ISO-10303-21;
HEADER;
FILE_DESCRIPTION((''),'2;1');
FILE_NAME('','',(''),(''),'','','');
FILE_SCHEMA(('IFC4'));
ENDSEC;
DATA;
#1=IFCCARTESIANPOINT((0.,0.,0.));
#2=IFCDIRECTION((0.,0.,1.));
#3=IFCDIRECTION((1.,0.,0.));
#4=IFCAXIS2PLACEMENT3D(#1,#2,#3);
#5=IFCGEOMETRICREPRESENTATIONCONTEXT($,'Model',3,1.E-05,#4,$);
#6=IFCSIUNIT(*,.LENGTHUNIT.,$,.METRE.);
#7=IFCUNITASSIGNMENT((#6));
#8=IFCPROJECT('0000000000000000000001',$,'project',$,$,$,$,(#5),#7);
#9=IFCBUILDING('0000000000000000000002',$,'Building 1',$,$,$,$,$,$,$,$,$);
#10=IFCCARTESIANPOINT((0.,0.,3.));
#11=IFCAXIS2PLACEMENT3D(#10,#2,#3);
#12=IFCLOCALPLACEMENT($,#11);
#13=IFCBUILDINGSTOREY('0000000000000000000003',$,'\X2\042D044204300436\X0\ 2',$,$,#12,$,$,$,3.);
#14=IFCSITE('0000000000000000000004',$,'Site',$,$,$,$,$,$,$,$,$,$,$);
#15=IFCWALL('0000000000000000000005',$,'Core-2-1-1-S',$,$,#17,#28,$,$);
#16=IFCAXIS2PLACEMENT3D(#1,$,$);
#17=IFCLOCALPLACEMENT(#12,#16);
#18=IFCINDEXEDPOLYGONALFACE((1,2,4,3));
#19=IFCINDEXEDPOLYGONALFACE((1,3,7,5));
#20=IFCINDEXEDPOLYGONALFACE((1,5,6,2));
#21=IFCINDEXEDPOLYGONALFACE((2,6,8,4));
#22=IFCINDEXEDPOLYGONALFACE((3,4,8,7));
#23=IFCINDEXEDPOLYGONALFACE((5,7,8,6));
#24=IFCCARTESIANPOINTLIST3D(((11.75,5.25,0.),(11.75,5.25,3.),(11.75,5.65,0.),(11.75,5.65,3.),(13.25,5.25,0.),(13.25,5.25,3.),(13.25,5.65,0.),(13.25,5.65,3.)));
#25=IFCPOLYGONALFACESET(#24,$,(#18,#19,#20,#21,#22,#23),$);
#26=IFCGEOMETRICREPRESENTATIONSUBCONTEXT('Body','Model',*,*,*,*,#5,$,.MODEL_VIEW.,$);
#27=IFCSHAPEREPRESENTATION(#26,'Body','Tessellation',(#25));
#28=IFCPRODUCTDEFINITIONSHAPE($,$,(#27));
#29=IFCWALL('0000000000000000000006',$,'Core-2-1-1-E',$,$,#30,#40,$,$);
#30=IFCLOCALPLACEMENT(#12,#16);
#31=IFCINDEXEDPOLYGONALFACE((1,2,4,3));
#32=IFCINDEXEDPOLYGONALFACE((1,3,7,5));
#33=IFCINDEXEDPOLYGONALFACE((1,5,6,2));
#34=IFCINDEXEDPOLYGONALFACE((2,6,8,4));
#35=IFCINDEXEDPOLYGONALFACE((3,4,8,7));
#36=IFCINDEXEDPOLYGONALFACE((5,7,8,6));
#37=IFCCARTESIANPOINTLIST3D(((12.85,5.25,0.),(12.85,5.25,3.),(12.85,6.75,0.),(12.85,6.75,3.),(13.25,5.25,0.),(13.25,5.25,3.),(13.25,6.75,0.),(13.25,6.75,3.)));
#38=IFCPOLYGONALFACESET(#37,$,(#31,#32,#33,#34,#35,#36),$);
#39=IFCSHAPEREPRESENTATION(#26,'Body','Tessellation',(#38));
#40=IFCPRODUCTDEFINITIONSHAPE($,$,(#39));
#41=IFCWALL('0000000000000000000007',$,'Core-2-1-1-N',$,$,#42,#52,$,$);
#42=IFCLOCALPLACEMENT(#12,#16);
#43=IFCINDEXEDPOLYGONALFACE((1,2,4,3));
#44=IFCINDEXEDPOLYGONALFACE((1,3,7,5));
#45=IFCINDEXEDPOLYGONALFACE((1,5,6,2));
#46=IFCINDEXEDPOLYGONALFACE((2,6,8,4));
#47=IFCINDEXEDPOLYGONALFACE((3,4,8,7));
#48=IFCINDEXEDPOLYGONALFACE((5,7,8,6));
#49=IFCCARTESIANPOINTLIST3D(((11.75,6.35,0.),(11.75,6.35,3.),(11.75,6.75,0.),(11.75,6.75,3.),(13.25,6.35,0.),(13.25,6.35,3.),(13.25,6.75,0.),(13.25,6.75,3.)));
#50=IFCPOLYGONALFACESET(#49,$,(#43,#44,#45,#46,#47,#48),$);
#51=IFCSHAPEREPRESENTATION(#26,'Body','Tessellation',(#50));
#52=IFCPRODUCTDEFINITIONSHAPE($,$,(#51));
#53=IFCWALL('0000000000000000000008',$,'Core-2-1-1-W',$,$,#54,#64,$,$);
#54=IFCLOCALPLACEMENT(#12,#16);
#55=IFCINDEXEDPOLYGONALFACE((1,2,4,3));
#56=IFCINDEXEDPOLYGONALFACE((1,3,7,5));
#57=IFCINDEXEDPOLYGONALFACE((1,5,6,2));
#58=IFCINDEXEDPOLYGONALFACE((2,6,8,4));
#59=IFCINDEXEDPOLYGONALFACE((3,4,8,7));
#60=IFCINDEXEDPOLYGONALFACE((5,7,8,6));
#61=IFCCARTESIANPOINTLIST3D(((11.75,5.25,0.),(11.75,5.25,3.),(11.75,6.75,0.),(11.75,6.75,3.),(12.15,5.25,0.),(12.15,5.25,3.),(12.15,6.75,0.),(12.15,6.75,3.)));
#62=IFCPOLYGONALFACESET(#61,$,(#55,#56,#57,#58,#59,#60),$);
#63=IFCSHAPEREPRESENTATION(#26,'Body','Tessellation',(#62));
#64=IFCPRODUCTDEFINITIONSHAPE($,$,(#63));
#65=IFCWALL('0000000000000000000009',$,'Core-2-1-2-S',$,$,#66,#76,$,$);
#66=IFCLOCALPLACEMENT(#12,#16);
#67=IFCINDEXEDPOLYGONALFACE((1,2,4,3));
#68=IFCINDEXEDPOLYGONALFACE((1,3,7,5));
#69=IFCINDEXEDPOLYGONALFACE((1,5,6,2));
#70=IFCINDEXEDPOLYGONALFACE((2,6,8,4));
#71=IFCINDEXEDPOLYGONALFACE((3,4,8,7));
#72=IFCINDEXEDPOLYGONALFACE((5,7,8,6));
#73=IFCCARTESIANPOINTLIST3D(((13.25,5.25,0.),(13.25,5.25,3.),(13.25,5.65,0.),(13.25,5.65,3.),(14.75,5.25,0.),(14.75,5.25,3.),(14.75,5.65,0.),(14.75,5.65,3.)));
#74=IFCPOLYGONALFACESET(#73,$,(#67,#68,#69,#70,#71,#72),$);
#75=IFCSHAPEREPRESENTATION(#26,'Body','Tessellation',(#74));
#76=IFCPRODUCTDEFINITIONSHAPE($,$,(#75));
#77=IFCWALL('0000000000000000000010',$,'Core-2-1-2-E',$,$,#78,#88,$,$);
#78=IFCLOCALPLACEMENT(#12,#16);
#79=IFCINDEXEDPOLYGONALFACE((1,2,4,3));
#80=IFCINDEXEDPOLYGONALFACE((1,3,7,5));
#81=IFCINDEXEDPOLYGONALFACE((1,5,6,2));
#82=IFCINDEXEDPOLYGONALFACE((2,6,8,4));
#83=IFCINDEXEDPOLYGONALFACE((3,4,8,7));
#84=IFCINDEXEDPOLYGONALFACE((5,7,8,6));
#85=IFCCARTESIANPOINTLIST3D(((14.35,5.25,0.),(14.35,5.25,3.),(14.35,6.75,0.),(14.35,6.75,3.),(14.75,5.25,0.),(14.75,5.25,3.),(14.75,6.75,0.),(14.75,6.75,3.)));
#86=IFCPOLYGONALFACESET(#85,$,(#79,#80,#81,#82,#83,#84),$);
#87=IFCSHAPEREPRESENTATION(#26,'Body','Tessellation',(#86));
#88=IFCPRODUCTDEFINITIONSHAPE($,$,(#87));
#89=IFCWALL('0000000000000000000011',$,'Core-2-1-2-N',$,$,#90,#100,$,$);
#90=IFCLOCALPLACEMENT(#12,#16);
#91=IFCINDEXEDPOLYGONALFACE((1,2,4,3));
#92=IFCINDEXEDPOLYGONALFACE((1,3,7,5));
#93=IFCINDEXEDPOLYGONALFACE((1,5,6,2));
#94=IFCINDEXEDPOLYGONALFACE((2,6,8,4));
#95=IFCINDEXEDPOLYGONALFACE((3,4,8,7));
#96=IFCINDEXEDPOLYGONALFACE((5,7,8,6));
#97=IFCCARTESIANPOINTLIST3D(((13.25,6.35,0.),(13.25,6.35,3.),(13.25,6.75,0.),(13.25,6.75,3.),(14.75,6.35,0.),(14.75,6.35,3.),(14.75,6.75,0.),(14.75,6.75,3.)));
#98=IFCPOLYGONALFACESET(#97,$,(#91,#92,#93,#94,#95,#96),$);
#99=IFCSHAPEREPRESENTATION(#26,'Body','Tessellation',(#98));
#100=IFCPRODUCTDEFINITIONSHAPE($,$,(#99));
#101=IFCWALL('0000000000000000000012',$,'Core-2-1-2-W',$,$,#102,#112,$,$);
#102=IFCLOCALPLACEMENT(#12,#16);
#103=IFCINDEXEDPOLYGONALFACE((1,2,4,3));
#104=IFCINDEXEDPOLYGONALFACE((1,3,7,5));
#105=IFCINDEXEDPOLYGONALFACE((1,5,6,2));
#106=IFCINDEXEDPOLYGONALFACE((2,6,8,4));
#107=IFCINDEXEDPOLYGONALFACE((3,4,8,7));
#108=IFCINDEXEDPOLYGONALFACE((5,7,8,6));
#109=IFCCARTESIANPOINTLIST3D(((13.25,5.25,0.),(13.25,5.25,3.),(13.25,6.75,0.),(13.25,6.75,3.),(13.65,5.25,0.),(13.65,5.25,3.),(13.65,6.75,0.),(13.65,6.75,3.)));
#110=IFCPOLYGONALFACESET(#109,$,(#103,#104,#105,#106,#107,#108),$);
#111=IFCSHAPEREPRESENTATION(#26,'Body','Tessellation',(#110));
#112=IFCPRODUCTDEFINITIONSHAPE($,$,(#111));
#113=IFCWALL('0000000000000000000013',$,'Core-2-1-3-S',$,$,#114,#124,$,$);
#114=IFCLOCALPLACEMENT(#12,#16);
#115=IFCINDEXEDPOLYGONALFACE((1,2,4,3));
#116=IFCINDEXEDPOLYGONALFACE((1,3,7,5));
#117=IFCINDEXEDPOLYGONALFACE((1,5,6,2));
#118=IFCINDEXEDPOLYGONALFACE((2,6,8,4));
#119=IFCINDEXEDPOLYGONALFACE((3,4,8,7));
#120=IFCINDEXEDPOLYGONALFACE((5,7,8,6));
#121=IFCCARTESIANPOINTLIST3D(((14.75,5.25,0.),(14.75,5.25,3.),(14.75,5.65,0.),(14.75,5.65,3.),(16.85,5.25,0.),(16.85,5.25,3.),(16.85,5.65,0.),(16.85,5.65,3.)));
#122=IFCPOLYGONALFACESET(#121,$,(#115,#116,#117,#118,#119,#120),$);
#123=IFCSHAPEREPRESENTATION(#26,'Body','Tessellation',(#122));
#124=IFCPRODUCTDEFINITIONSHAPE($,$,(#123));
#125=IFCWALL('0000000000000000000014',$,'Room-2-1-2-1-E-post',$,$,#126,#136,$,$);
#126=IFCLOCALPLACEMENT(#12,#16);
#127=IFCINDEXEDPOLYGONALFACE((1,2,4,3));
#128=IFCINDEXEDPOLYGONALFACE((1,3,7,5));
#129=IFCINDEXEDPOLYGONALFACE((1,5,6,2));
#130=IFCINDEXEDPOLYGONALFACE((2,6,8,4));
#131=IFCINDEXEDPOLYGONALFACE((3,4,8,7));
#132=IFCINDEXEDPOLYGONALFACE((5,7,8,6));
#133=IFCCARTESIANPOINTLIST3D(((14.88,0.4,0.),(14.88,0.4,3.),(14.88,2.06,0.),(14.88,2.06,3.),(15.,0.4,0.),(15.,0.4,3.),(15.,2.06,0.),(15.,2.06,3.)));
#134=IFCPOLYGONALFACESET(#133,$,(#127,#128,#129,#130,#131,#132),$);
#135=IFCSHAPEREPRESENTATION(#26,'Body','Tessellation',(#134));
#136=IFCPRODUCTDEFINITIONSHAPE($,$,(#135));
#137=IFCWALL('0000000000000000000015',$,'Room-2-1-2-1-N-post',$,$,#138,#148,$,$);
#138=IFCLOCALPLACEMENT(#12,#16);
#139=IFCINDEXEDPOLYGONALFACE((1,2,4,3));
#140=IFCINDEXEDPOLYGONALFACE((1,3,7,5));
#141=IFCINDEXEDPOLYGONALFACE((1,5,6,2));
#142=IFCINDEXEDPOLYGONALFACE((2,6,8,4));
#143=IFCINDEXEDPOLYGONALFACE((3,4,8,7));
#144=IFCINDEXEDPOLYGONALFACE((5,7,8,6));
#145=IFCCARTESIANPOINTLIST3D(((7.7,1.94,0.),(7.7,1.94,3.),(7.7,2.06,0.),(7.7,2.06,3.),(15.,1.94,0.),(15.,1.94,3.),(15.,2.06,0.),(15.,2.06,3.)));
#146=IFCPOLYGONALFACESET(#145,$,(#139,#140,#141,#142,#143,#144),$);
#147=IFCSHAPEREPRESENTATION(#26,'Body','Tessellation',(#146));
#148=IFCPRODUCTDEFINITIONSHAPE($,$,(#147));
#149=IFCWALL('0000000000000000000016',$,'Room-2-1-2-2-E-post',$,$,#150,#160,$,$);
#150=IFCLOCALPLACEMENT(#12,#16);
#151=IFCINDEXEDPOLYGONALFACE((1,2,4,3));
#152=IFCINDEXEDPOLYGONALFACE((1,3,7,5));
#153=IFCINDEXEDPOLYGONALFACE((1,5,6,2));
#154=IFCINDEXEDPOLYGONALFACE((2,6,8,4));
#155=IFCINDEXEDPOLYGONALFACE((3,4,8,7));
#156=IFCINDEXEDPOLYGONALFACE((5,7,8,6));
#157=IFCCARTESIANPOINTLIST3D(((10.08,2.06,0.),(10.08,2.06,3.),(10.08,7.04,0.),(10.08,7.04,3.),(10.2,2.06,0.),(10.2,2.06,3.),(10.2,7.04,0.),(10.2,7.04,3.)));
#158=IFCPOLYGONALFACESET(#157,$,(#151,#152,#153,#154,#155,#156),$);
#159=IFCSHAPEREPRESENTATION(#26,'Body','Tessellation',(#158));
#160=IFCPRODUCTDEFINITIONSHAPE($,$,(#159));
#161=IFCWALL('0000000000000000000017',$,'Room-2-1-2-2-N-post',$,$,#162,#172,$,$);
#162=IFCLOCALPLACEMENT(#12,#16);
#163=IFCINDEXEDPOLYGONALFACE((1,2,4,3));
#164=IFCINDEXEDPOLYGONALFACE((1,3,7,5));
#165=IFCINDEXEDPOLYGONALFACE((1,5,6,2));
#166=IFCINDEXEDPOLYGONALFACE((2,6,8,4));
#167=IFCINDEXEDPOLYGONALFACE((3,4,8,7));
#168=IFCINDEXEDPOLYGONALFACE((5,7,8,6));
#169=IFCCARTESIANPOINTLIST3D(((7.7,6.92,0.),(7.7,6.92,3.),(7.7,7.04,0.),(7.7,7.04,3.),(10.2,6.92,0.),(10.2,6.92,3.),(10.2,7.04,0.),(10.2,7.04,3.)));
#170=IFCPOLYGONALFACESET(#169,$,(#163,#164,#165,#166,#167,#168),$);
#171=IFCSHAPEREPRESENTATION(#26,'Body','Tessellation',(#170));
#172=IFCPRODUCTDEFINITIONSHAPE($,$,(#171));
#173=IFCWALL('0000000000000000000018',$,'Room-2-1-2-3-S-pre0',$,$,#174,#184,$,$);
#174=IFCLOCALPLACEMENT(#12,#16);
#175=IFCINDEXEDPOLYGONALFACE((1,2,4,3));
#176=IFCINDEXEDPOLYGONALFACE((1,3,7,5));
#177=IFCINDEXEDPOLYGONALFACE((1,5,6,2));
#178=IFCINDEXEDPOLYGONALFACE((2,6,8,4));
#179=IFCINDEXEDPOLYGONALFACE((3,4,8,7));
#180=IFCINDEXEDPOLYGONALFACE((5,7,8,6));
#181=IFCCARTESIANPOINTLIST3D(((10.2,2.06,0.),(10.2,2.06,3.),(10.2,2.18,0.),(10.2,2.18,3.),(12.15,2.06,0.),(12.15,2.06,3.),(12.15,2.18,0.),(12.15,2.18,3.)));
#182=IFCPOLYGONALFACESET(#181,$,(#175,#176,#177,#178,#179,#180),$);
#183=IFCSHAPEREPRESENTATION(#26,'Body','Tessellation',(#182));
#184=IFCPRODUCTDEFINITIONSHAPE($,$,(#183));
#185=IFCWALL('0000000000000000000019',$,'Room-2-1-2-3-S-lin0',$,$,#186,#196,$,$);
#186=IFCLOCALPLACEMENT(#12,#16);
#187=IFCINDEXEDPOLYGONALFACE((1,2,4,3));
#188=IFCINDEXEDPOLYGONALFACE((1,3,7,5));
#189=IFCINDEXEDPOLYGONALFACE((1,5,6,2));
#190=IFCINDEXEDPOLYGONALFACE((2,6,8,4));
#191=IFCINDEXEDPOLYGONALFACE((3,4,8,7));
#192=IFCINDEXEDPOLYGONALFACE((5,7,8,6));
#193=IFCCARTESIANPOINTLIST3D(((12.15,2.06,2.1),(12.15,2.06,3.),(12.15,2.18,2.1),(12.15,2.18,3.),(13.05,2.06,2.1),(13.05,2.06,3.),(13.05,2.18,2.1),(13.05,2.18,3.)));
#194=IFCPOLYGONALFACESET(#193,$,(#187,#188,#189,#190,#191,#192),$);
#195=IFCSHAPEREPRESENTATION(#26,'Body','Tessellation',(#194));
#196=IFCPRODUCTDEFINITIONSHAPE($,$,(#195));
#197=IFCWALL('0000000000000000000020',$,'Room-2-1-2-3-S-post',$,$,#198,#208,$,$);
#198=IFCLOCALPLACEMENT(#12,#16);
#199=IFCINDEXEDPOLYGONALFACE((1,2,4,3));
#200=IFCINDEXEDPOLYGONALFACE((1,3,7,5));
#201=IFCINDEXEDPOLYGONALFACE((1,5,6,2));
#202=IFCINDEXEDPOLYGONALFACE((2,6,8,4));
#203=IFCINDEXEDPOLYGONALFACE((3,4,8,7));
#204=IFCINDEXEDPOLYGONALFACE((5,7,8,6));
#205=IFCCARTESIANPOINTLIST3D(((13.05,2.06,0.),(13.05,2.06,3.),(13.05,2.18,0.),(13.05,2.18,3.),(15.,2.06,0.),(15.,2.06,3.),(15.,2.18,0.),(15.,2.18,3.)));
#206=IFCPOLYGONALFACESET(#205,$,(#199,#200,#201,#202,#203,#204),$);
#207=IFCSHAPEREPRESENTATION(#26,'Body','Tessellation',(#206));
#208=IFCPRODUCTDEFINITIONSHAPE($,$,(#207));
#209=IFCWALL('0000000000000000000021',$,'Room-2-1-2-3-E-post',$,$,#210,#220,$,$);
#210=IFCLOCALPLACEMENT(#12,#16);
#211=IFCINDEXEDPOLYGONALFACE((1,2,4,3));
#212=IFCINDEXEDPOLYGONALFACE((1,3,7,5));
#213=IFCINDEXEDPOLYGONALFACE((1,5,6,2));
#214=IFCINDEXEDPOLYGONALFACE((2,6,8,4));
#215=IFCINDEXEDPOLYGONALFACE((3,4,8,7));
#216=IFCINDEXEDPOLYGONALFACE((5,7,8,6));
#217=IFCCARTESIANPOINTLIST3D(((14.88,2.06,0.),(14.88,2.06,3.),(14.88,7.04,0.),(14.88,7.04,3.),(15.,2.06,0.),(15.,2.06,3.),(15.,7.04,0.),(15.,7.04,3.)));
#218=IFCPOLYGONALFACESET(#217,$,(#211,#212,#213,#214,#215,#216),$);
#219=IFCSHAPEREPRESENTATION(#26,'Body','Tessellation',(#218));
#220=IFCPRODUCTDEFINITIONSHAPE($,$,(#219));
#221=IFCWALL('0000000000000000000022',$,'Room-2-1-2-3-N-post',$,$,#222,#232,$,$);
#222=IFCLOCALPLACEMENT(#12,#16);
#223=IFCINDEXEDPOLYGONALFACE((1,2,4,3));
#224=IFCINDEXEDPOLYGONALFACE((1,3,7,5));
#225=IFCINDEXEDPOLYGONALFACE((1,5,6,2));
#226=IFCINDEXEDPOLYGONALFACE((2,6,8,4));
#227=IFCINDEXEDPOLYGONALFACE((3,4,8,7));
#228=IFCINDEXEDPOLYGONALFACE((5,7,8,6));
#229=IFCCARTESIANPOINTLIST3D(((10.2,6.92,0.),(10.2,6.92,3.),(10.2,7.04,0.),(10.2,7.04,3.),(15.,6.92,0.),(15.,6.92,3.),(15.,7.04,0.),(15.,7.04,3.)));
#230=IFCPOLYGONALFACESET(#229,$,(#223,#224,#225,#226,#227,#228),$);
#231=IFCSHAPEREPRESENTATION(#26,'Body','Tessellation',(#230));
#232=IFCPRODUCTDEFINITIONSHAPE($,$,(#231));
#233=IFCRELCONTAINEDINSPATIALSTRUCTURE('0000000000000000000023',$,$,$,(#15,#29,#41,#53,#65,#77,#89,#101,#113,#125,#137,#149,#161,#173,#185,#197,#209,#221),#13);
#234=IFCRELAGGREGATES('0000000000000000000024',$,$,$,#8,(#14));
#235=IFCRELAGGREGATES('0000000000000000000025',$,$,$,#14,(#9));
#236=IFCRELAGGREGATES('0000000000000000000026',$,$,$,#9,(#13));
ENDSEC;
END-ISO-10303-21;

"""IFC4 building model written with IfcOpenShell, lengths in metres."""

from ifc_helpers import new_model, si_unit, frame, origin_with_axes, place, context, subcontext, project, spatial, indexed_curve, outline, extrude, element, save


model = new_model("IFC4")

# Units and contexts
model_context = context("Model", 3, precision=1e-05, world=origin_with_axes())
body_context = subcontext(model_context, "Body", "Model", "MODEL_VIEW")
ifc_project = project(units=[si_unit("LENGTHUNIT", "METRE")], contexts=[model_context])

# Site, building, storey
site = spatial("IfcSite", under=ifc_project, Name="Site")
building = spatial("IfcBuilding", under=site, Name="Building 1")
storey_placement = place(None, frame((0.0, 0.0, 3.0), z_axis=(0.0, 0.0, 1.0), x_axis=(1.0, 0.0, 0.0)))
storey = spatial("IfcBuildingStorey", under=building, at=storey_placement, Name="Этаж 2", Elevation=3.0)

# Walls
for number, where, z_axis, x_axis, name in (
    (1, (11.75, 5.25, 0.0), (0.0, 0.0, 1.0), (1.0, 0.0, 0.0), "Core-2-1-1-S"),
    (2, (13.25, 5.25, 0.0), (0.0, 0.0, 1.0), (0.0, 1.0, 0.0), "Core-2-1-1-E"),
    (3, (13.25, 6.75, 0.0), (0.0, 0.0, 1.0), (-1.0, 0.0, 0.0), "Core-2-1-1-N"),
    (4, (11.75, 6.75, 0.0), (0.0, 0.0, 1.0), (0.0, -1.0, 0.0), "Core-2-1-1-W"),
    (5, (13.25, 5.25, 0.0), (0.0, 0.0, 1.0), (1.0, 0.0, 0.0), "Core-2-1-2-S"),
    (6, (14.75, 5.25, 0.0), (0.0, 0.0, 1.0), (0.0, 1.0, 0.0), "Core-2-1-2-E"),
    (7, (14.75, 6.75, 0.0), (0.0, 0.0, 1.0), (-1.0, 0.0, 0.0), "Core-2-1-2-N"),
    (8, (13.25, 6.75, 0.0), (0.0, 0.0, 1.0), (0.0, -1.0, 0.0), "Core-2-1-2-W"),
):
    element("IfcWall", number, at=place(storey_placement, frame(where, z_axis=z_axis, x_axis=x_axis)), inside=storey, Name=name, context=body_context, shape_type="SweptSolid", body=[
        extrude(outline(indexed_curve([(0.0, 0.0), (0.0, 0.4), (1.5, 0.4), (1.5, 0.0), (0.0, 0.0)], self_intersect=False)), origin_with_axes(), (0.0, 0.0, 1.0), 3.0),
    ])
wall_1_placement = place(storey_placement, frame((14.75, 5.25, 0.0), z_axis=(0.0, 0.0, 1.0), x_axis=(1.0, 0.0, 0.0)))
element("IfcWall", 9, at=wall_1_placement, inside=storey, Name="Core-2-1-3-S", context=body_context, shape_type="SweptSolid", body=[
    extrude(outline(indexed_curve([(0.0, 0.0), (0.0, 0.4), (2.1, 0.4), (2.1, 0.0), (0.0, 0.0)], self_intersect=False)), origin_with_axes(), (0.0, 0.0, 1.0), 3.0),
])
wall_2_placement = place(storey_placement, frame((15.0, 0.4, 0.0), z_axis=(0.0, 0.0, 1.0), x_axis=(0.0, 1.0, 0.0)))
element("IfcWall", 10, at=wall_2_placement, inside=storey, Name="Room-2-1-2-1-E-post", context=body_context, shape_type="SweptSolid", body=[
    extrude(outline(indexed_curve([(0.0, 0.0), (0.0, 0.12), (1.66, 0.12), (1.66, 0.0), (0.0, 0.0)], self_intersect=False)), origin_with_axes(), (0.0, 0.0, 1.0), 3.0),
])
wall_3_placement = place(storey_placement, frame((15.0, 2.06, 0.0), z_axis=(0.0, 0.0, 1.0), x_axis=(-1.0, 0.0, 0.0)))
element("IfcWall", 11, at=wall_3_placement, inside=storey, Name="Room-2-1-2-1-N-post", context=body_context, shape_type="SweptSolid", body=[
    extrude(outline(indexed_curve([(0.0, 0.0), (0.0, 0.12), (7.3, 0.12), (7.3, 0.0), (0.0, 0.0)], self_intersect=False)), origin_with_axes(), (0.0, 0.0, 1.0), 3.0),
])
wall_4_placement = place(storey_placement, frame((10.2, 2.06, 0.0), z_axis=(0.0, 0.0, 1.0), x_axis=(0.0, 1.0, 0.0)))
element("IfcWall", 12, at=wall_4_placement, inside=storey, Name="Room-2-1-2-2-E-post", context=body_context, shape_type="SweptSolid", body=[
    extrude(outline(indexed_curve([(0.0, 0.0), (0.0, 0.12), (4.98, 0.12), (4.98, 0.0), (0.0, 0.0)], self_intersect=False)), origin_with_axes(), (0.0, 0.0, 1.0), 3.0),
])
wall_5_placement = place(storey_placement, frame((10.2, 7.04, 0.0), z_axis=(0.0, 0.0, 1.0), x_axis=(-1.0, 0.0, 0.0)))
element("IfcWall", 13, at=wall_5_placement, inside=storey, Name="Room-2-1-2-2-N-post", context=body_context, shape_type="SweptSolid", body=[
    extrude(outline(indexed_curve([(0.0, 0.0), (0.0, 0.12), (2.5, 0.12), (2.5, 0.0), (0.0, 0.0)], self_intersect=False)), origin_with_axes(), (0.0, 0.0, 1.0), 3.0),
])
wall_6_placement = place(storey_placement, frame((10.2, 2.06, 0.0), z_axis=(0.0, 0.0, 1.0), x_axis=(1.0, 0.0, 0.0)))
element("IfcWall", 14, at=wall_6_placement, inside=storey, Name="Room-2-1-2-3-S-pre0", context=body_context, shape_type="SweptSolid", body=[
    extrude(outline(indexed_curve([(0.0, 0.0), (0.0, 0.12), (1.95, 0.12), (1.95, 0.0), (0.0, 0.0)], self_intersect=False)), origin_with_axes(), (0.0, 0.0, 1.0), 3.0),
])
wall_7_placement = place(storey_placement, frame((12.15, 2.06, 2.1), z_axis=(0.0, 0.0, 1.0), x_axis=(1.0, 0.0, 0.0)))
element("IfcWall", 15, at=wall_7_placement, inside=storey, Name="Room-2-1-2-3-S-lin0", context=body_context, shape_type="SweptSolid", body=[
    extrude(outline(indexed_curve([(0.0, 0.0), (0.0, 0.12), (0.9, 0.12), (0.9, 0.0), (0.0, 0.0)], self_intersect=False)), origin_with_axes(), (0.0, 0.0, 1.0), 0.9),
])
wall_8_placement = place(storey_placement, frame((13.05, 2.06, 0.0), z_axis=(0.0, 0.0, 1.0), x_axis=(1.0, 0.0, 0.0)))
element("IfcWall", 16, at=wall_8_placement, inside=storey, Name="Room-2-1-2-3-S-post", context=body_context, shape_type="SweptSolid", body=[
    extrude(outline(indexed_curve([(0.0, 0.0), (0.0, 0.12), (1.95, 0.12), (1.95, 0.0), (0.0, 0.0)], self_intersect=False)), origin_with_axes(), (0.0, 0.0, 1.0), 3.0),
])
wall_9_placement = place(storey_placement, frame((15.0, 2.06, 0.0), z_axis=(0.0, 0.0, 1.0), x_axis=(0.0, 1.0, 0.0)))
element("IfcWall", 17, at=wall_9_placement, inside=storey, Name="Room-2-1-2-3-E-post", context=body_context, shape_type="SweptSolid", body=[
    extrude(outline(indexed_curve([(0.0, 0.0), (0.0, 0.12), (4.98, 0.12), (4.98, 0.0), (0.0, 0.0)], self_intersect=False)), origin_with_axes(), (0.0, 0.0, 1.0), 3.0),
])
wall_10_placement = place(storey_placement, frame((15.0, 7.04, 0.0), z_axis=(0.0, 0.0, 1.0), x_axis=(-1.0, 0.0, 0.0)))
element("IfcWall", 18, at=wall_10_placement, inside=storey, Name="Room-2-1-2-3-N-post", context=body_context, shape_type="SweptSolid", body=[
    extrude(outline(indexed_curve([(0.0, 0.0), (0.0, 0.12), (4.8, 0.12), (4.8, 0.0), (0.0, 0.0)], self_intersect=False)), origin_with_axes(), (0.0, 0.0, 1.0), 3.0),
])

save(model, "model.ifc")
